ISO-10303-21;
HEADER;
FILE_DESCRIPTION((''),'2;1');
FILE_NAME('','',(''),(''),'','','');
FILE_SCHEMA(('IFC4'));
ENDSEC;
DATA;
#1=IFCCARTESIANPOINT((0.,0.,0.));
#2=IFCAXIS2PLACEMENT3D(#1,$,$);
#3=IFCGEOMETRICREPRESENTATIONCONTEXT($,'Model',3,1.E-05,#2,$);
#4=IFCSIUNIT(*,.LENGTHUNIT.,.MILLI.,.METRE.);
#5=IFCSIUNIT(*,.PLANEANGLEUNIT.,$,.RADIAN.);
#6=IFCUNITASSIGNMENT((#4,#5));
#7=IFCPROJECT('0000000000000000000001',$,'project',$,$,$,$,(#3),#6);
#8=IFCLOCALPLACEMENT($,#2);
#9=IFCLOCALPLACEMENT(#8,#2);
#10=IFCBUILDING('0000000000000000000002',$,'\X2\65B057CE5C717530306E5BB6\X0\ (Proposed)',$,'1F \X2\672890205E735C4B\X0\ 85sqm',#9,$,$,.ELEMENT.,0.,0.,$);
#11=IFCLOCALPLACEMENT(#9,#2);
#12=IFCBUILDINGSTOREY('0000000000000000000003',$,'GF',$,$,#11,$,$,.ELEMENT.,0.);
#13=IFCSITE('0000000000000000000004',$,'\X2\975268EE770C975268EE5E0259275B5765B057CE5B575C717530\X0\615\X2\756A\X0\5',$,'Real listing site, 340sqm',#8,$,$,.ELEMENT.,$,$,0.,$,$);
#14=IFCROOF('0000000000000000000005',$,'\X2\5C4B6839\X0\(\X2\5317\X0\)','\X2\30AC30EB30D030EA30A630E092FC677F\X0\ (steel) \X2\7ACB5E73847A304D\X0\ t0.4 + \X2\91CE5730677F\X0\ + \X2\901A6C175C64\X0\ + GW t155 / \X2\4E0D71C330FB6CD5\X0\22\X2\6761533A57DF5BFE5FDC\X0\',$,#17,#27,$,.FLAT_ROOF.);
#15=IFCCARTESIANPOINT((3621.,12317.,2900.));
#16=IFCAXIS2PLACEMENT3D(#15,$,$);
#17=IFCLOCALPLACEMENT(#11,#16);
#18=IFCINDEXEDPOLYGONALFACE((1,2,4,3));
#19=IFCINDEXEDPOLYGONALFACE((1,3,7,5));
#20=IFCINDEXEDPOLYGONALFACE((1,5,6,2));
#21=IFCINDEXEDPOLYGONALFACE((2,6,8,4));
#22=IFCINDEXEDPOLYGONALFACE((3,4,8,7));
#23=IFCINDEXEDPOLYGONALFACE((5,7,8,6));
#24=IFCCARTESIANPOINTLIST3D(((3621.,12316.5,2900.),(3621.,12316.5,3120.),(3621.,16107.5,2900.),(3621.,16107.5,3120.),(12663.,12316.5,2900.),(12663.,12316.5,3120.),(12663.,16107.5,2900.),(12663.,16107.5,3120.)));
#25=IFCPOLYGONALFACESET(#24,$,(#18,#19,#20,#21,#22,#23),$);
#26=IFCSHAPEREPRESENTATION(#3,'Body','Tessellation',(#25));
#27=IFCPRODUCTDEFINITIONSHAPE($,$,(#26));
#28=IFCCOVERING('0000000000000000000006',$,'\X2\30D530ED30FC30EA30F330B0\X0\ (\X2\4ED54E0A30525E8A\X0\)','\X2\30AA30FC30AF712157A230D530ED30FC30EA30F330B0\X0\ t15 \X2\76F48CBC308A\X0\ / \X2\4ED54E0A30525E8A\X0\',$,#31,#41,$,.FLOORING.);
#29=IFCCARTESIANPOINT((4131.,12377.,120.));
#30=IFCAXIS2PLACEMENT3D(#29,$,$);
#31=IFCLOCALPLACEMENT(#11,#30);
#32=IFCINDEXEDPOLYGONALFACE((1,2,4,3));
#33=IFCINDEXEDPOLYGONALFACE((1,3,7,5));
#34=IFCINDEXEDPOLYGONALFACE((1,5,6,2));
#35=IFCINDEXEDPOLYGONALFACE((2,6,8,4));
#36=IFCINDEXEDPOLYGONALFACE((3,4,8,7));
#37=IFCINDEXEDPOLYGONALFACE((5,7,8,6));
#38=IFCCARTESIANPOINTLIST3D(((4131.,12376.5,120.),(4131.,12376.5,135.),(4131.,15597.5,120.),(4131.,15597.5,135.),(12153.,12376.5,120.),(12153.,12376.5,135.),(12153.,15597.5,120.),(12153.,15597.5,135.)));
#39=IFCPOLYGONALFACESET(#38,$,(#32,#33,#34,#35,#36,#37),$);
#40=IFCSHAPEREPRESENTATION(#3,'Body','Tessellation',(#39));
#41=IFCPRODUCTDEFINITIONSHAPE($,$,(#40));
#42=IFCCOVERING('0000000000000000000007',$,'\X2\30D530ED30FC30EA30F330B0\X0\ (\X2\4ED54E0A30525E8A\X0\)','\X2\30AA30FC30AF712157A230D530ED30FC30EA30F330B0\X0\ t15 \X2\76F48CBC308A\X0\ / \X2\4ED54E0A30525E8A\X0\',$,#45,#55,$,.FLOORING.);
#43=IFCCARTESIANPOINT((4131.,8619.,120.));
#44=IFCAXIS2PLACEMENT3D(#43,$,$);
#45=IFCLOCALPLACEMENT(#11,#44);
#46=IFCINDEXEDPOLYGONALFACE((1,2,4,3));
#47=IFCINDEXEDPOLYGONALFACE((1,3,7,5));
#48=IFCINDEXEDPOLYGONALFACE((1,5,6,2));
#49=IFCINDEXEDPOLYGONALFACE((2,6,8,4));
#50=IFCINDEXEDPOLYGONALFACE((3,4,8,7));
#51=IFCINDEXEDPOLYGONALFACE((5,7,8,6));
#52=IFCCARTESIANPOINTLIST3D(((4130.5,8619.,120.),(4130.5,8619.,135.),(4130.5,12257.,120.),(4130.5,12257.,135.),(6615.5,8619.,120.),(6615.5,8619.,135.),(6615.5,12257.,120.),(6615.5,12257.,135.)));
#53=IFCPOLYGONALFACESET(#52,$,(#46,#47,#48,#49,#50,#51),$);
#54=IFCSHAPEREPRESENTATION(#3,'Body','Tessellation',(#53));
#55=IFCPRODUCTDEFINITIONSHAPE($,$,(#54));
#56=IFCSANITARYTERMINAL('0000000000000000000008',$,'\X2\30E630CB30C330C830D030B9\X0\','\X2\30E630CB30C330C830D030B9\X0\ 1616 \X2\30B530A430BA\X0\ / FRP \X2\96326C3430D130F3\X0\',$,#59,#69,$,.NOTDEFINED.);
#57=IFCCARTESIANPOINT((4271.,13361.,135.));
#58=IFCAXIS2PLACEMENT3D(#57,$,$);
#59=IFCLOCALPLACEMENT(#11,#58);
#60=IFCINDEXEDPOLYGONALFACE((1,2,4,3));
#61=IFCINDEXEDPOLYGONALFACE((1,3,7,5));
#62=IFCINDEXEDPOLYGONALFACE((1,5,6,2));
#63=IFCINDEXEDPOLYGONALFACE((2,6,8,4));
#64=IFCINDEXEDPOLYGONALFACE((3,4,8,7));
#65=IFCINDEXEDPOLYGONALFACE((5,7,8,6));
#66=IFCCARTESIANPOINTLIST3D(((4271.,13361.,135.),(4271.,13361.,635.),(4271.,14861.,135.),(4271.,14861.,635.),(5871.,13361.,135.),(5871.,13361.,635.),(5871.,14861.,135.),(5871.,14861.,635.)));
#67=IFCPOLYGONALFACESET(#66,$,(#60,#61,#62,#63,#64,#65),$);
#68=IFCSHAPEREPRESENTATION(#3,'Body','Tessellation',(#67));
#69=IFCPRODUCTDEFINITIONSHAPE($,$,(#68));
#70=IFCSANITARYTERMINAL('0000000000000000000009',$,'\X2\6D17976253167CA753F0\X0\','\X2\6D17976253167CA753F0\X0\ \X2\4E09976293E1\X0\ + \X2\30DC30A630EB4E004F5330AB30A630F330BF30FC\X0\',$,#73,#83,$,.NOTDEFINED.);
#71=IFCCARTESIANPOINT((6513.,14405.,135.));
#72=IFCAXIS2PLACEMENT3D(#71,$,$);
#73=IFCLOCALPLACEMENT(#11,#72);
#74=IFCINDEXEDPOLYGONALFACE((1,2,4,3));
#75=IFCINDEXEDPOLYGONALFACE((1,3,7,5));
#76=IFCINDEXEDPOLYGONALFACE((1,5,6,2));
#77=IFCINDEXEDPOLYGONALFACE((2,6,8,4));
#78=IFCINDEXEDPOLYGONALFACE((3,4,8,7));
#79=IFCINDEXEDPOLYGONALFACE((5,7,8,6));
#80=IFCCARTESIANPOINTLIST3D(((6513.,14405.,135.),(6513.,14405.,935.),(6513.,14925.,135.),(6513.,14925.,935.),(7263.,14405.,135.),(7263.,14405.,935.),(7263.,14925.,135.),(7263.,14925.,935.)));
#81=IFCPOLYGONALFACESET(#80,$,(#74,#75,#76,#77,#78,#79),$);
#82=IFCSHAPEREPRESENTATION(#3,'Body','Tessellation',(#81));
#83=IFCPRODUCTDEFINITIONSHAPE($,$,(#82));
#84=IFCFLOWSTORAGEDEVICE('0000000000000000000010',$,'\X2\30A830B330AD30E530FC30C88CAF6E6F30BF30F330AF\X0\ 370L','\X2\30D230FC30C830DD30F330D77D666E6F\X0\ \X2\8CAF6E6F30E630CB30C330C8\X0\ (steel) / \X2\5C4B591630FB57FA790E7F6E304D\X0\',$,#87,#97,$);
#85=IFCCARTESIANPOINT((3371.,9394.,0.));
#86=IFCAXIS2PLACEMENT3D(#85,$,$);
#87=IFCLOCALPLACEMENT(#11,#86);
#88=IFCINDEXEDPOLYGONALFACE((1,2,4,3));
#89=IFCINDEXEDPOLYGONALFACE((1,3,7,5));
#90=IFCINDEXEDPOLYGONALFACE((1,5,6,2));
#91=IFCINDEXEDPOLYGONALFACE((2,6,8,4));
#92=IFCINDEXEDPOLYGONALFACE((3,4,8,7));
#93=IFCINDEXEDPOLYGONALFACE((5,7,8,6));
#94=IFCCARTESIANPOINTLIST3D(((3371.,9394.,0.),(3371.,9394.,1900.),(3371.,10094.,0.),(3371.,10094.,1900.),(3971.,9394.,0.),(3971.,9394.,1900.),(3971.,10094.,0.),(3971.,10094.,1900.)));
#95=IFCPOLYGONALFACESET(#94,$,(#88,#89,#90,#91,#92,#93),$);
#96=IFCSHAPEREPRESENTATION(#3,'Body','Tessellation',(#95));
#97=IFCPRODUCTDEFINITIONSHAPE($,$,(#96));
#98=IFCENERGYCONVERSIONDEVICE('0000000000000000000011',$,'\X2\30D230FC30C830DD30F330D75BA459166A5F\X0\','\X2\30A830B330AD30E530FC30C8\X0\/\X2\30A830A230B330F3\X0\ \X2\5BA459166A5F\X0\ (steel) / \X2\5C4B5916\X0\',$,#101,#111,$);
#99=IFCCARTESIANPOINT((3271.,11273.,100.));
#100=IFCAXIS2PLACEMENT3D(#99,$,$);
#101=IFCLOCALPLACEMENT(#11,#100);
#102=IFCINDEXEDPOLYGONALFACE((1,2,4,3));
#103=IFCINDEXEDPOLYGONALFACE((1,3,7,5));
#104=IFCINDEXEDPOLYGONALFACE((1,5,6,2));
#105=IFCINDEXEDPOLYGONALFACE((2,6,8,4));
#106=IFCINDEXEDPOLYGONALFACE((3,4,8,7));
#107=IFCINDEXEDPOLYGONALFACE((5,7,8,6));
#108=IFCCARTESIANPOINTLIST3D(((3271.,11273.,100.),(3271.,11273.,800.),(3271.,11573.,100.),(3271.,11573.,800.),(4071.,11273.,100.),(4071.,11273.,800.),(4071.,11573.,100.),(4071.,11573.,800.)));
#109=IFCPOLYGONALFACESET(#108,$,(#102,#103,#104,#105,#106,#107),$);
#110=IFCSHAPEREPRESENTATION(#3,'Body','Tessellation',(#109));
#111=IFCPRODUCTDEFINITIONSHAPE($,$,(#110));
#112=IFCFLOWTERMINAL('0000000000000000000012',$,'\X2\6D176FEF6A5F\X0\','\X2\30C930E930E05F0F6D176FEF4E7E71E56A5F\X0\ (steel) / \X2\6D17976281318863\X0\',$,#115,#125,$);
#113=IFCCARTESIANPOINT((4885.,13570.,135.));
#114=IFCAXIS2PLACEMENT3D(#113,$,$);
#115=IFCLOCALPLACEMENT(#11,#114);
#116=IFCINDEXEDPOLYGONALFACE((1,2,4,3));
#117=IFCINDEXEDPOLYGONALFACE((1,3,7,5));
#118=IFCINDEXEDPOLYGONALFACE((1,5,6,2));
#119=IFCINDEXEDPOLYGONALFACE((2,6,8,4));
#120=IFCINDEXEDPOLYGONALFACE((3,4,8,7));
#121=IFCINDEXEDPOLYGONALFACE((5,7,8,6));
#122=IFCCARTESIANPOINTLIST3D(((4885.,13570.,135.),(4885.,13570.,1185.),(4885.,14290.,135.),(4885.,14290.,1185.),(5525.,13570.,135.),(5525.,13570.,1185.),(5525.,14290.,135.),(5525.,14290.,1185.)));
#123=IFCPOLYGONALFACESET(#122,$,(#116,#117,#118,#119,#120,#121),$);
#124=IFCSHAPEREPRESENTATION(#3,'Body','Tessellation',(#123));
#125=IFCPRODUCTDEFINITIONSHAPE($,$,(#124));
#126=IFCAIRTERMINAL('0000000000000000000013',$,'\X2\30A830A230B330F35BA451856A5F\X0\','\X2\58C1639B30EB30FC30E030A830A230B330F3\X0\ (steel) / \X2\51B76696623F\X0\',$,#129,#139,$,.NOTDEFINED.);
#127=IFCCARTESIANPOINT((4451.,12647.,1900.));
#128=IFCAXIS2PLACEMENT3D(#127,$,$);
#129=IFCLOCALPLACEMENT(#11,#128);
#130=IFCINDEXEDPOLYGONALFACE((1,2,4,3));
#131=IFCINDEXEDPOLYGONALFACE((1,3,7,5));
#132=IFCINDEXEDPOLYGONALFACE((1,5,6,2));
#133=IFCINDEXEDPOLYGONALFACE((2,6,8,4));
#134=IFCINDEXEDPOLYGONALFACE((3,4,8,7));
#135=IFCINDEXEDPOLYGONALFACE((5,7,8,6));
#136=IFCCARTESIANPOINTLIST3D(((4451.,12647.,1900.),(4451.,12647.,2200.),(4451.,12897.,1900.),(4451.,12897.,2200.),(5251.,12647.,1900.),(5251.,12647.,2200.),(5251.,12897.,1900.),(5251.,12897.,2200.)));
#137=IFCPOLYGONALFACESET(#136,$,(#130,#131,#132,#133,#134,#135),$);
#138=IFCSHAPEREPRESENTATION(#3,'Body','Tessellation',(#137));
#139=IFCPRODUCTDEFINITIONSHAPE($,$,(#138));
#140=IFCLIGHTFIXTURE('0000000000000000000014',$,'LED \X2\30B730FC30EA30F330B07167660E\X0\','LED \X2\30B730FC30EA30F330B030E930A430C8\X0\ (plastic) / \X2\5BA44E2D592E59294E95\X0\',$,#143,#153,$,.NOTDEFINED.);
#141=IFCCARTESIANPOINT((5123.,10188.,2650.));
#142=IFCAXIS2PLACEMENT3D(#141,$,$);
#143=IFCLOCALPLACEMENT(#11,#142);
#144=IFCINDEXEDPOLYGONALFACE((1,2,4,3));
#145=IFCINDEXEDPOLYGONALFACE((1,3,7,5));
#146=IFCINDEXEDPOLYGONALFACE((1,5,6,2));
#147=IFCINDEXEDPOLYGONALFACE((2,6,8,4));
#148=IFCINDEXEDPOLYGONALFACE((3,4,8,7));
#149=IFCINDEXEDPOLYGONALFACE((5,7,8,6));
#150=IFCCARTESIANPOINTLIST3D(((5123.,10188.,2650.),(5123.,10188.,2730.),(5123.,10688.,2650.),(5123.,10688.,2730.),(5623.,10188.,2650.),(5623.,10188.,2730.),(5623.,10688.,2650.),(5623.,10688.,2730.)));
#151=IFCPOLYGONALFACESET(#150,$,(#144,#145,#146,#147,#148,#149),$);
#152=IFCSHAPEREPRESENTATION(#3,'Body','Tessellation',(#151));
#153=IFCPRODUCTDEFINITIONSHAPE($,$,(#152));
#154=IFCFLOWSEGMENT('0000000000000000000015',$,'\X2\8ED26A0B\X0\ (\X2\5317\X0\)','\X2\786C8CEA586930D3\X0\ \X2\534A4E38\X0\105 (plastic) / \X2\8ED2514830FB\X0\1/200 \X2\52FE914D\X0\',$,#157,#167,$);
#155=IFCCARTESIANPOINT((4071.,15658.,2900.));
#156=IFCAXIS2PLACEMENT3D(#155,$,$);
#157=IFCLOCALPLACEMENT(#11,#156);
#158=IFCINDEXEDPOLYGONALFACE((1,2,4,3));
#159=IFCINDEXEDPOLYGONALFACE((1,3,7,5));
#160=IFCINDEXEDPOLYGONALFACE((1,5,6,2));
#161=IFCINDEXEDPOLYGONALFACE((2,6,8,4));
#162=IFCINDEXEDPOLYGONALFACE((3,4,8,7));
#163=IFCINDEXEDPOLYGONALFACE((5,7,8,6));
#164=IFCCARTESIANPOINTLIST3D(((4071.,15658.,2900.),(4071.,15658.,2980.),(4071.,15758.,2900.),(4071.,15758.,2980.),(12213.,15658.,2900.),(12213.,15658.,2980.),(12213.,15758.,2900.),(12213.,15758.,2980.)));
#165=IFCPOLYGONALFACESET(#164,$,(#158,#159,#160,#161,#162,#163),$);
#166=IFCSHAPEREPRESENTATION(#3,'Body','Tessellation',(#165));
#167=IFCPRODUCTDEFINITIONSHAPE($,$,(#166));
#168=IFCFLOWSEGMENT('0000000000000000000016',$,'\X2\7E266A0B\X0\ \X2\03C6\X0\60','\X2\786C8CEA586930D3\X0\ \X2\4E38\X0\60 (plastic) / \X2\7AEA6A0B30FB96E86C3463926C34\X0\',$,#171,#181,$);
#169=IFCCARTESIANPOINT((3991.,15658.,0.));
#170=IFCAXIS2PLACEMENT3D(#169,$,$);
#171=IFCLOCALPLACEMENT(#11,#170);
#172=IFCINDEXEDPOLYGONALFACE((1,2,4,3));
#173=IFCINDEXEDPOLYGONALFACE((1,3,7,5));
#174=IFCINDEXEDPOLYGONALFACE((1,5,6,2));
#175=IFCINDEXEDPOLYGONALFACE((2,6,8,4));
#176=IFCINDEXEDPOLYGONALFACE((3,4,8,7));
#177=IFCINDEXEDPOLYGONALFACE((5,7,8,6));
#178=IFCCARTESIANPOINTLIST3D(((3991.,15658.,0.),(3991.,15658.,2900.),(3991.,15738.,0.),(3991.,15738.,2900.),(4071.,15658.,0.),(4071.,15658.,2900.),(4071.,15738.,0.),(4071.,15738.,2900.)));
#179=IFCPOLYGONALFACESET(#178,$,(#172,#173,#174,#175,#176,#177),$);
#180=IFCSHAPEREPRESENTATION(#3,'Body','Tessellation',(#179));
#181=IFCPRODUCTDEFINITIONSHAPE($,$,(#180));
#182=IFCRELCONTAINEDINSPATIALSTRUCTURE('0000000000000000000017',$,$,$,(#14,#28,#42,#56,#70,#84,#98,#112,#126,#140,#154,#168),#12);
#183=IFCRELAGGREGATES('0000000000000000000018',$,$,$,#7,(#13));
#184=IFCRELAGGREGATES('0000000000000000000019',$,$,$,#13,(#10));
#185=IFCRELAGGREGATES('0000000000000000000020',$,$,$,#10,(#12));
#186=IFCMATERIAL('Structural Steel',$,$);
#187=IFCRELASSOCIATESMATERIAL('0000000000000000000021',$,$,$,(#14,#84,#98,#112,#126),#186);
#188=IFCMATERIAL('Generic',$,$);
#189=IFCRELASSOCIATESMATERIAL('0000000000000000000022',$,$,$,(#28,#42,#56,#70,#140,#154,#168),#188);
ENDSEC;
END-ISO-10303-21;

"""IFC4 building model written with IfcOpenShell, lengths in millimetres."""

from ifc_helpers import new_model, si_unit, frame, frame_2d, origin, place, context, project, spatial, rectangle, extrude, material, element, save


model = new_model("IFC4")

# Units and contexts
model_context = context("Model", 3, precision=1e-05, world=origin())
ifc_project = project(units=[si_unit("LENGTHUNIT", "METRE", prefix="MILLI"), si_unit("PLANEANGLEUNIT", "RADIAN")], contexts=[model_context])

# Site, building, storey
site_placement = place(None, origin())
site = spatial("IfcSite", under=ifc_project, at=site_placement, Name="青森県青森市大字新城字山田615番5", ObjectType="Real listing site, 340sqm", CompositionType="ELEMENT", RefElevation=0.0)
building_placement = place(site_placement, origin())
building = spatial("IfcBuilding", under=site, at=building_placement, Name="新城山田の家 (Proposed)", ObjectType="1F 木造平屋 85sqm", CompositionType="ELEMENT", ElevationOfRefHeight=0.0, ElevationOfTerrain=0.0)
storey_placement = place(building_placement, origin())
storey = spatial("IfcBuildingStorey", under=building, at=storey_placement, Name="GF", CompositionType="ELEMENT", Elevation=0.0)

# Roof
ifc_material_1 = material(Name="Structural Steel")
roof_placement = place(storey_placement, frame((3621.0, 12317.0, 2900.0)))
element("IfcRoof", 1, at=roof_placement, inside=storey, material=ifc_material_1, Name="屋根(北)", Description="ガルバリウム鋼板 (steel) 立平葺き t0.4 + 野地板 + 通気層 + GW t155 / 不燃・法22条区域対応", PredefinedType="FLAT_ROOF", context=model_context, shape_type="SweptSolid", body=[
    extrude(rectangle(XDim=9042.0, YDim=3791.0, at=frame_2d((4521.0, 1895.0))), frame((3621.0, 12317.0, 2900.0)), (0.0, 0.0, 1.0), 220.0),
])

# Coverings
ifc_material_2 = material(Name="Generic")
covering_1_placement = place(storey_placement, frame((4131.0, 12377.0, 120.0)))
element("IfcCovering", 2, at=covering_1_placement, inside=storey, material=ifc_material_2, Name="フローリング (仕上げ床)", Description="オーク無垢フローリング t15 直貼り / 仕上げ床", PredefinedType="FLOORING", context=model_context, shape_type="SweptSolid", body=[
    extrude(rectangle(XDim=8022.0, YDim=3221.0, at=frame_2d((4011.0, 1610.0))), frame((4131.0, 12377.0, 120.0)), (0.0, 0.0, 1.0), 15.0),
])
covering_2_placement = place(storey_placement, frame((4131.0, 8619.0, 120.0)))
element("IfcCovering", 3, at=covering_2_placement, inside=storey, material=ifc_material_2, Name="フローリング (仕上げ床)", Description="オーク無垢フローリング t15 直貼り / 仕上げ床", PredefinedType="FLOORING", context=model_context, shape_type="SweptSolid", body=[
    extrude(rectangle(XDim=2485.0, YDim=3638.0, at=frame_2d((1242.0, 1819.0))), frame((4131.0, 8619.0, 120.0)), (0.0, 0.0, 1.0), 15.0),
])

# Sanitary terminals
sanitary_terminal_1_placement = place(storey_placement, frame((4271.0, 13361.0, 135.0)))
element("IfcSanitaryTerminal", 4, at=sanitary_terminal_1_placement, inside=storey, material=ifc_material_2, Name="ユニットバス", Description="ユニットバス 1616 サイズ / FRP 防水パン", PredefinedType="NOTDEFINED", context=model_context, shape_type="SweptSolid", body=[
    extrude(rectangle(XDim=1600.0, YDim=1500.0, at=frame_2d((800.0, 750.0))), frame((4271.0, 13361.0, 135.0)), (0.0, 0.0, 1.0), 500.0),
])
sanitary_terminal_2_placement = place(storey_placement, frame((6513.0, 14405.0, 135.0)))
element("IfcSanitaryTerminal", 5, at=sanitary_terminal_2_placement, inside=storey, material=ifc_material_2, Name="洗面化粧台", Description="洗面化粧台 三面鏡 + ボウル一体カウンター", PredefinedType="NOTDEFINED", context=model_context, shape_type="SweptSolid", body=[
    extrude(rectangle(XDim=750.0, YDim=520.0, at=frame_2d((375.0, 260.0))), frame((6513.0, 14405.0, 135.0)), (0.0, 0.0, 1.0), 800.0),
])

# Flow storage device
flow_storage_device_placement = place(storey_placement, frame((3371.0, 9394.0, 0.0)))
element("IfcFlowStorageDevice", 6, at=flow_storage_device_placement, inside=storey, material=ifc_material_1, Name="エコキュート貯湯タンク 370L", Description="ヒートポンプ給湯 貯湯ユニット (steel) / 屋外・基礎置き", context=model_context, shape_type="SweptSolid", body=[
    extrude(rectangle(XDim=600.0, YDim=700.0, at=frame_2d((300.0, 350.0))), frame((3371.0, 9394.0, 0.0)), (0.0, 0.0, 1.0), 1900.0),
])

# Energy conversion device
energy_conversion_device_placement = place(storey_placement, frame((3271.0, 11273.0, 100.0)))
element("IfcEnergyConversionDevice", 7, at=energy_conversion_device_placement, inside=storey, material=ifc_material_1, Name="ヒートポンプ室外機", Description="エコキュート/エアコン 室外機 (steel) / 屋外", context=model_context, shape_type="SweptSolid", body=[
    extrude(rectangle(XDim=800.0, YDim=300.0, at=frame_2d((400.0, 150.0))), frame((3271.0, 11273.0, 100.0)), (0.0, 0.0, 1.0), 700.0),
])

# Flow terminal
flow_terminal_placement = place(storey_placement, frame((4885.0, 13570.0, 135.0)))
element("IfcFlowTerminal", 8, at=flow_terminal_placement, inside=storey, material=ifc_material_1, Name="洗濯機", Description="ドラム式洗濯乾燥機 (steel) / 洗面脱衣", context=model_context, shape_type="SweptSolid", body=[
    extrude(rectangle(XDim=640.0, YDim=720.0, at=frame_2d((320.0, 360.0))), frame((4885.0, 13570.0, 135.0)), (0.0, 0.0, 1.0), 1050.0),
])

# Air terminal
air_terminal_placement = place(storey_placement, frame((4451.0, 12647.0, 1900.0)))
element("IfcAirTerminal", 9, at=air_terminal_placement, inside=storey, material=ifc_material_1, Name="エアコン室内機", Description="壁掛ルームエアコン (steel) / 冷暖房", PredefinedType="NOTDEFINED", context=model_context, shape_type="SweptSolid", body=[
    extrude(rectangle(XDim=800.0, YDim=250.0, at=frame_2d((400.0, 125.0))), frame((4451.0, 12647.0, 1900.0)), (0.0, 0.0, 1.0), 300.0),
])

# Light fixture
light_fixture_placement = place(storey_placement, frame((5123.0, 10188.0, 2650.0)))
element("IfcLightFixture", 10, at=light_fixture_placement, inside=storey, material=ifc_material_2, Name="LED シーリング照明", Description="LED シーリングライト (plastic) / 室中央天井", PredefinedType="NOTDEFINED", context=model_context, shape_type="SweptSolid", body=[
    extrude(rectangle(XDim=500.0, YDim=500.0, at=frame_2d((250.0, 250.0))), frame((5123.0, 10188.0, 2650.0)), (0.0, 0.0, 1.0), 80.0),
])

# Flow segments
flow_segment_1_placement = place(storey_placement, frame((4071.0, 15658.0, 2900.0)))
element("IfcFlowSegment", 11, at=flow_segment_1_placement, inside=storey, material=ifc_material_2, Name="軒樋 (北)", Description="硬質塩ビ 半丸105 (plastic) / 軒先・1/200 勾配", context=model_context, shape_type="SweptSolid", body=[
    extrude(rectangle(XDim=8142.0, YDim=100.0, at=frame_2d((4071.0, 50.0))), frame((4071.0, 15658.0, 2900.0)), (0.0, 0.0, 1.0), 80.0),
])
flow_segment_2_placement = place(storey_placement, frame((3991.0, 15658.0, 0.0)))
element("IfcFlowSegment", 12, at=flow_segment_2_placement, inside=storey, material=ifc_material_2, Name="縦樋 φ60", Description="硬質塩ビ 丸60 (plastic) / 竪樋・雨水排水", context=model_context, shape_type="SweptSolid", body=[
    extrude(rectangle(XDim=80.0, YDim=80.0, at=frame_2d((40.0, 40.0))), frame((3991.0, 15658.0, 0.0)), (0.0, 0.0, 1.0), 2900.0),
])

save(model, "model.ifc")
